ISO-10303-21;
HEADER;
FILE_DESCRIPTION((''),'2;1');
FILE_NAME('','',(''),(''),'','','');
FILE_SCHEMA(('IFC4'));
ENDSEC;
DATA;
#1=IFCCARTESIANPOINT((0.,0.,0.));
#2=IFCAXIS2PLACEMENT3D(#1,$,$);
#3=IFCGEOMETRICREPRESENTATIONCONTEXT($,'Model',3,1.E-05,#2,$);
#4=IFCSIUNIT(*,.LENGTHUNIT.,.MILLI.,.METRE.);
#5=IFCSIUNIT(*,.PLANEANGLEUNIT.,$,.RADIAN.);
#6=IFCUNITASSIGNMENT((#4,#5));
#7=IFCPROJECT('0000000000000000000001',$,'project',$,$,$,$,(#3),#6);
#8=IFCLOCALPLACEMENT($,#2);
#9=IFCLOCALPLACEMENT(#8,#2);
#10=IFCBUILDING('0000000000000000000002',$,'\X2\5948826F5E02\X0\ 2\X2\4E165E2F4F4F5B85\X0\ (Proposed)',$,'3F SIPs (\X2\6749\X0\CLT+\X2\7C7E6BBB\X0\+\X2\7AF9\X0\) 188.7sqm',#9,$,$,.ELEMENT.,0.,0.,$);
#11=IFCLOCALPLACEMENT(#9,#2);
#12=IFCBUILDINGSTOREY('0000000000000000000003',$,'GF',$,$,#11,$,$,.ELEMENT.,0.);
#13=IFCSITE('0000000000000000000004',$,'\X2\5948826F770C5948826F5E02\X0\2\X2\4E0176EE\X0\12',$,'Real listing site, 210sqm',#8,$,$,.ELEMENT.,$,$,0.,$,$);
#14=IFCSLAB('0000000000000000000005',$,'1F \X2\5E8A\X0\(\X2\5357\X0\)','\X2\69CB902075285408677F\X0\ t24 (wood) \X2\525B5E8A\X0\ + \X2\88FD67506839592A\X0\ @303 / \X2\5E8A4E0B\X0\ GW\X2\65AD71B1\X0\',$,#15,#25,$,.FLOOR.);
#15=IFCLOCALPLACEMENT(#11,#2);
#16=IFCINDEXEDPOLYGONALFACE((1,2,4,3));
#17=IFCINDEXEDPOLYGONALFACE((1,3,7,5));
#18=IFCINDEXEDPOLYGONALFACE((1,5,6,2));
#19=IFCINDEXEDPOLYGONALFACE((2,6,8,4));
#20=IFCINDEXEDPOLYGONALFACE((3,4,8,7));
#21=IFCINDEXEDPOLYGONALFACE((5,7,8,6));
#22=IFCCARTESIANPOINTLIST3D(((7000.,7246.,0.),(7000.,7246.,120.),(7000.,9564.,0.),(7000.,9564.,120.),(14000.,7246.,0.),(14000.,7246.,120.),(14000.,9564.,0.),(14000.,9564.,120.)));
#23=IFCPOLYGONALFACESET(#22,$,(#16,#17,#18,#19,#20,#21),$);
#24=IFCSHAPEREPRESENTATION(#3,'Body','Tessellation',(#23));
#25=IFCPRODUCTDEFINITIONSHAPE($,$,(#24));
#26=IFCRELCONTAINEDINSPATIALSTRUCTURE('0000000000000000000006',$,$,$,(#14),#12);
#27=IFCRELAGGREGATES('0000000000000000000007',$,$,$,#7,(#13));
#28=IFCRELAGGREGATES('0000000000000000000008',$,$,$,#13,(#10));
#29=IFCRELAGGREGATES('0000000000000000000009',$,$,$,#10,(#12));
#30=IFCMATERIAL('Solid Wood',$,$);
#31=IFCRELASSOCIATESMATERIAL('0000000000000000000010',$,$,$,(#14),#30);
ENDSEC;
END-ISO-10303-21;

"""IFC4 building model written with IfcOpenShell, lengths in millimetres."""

from ifc_helpers import new_model, si_unit, frame, frame_2d, origin, place, context, project, spatial, rectangle, extrude, material, element, save


model = new_model("IFC4")

# Units and contexts
model_context = context("Model", 3, precision=1e-05, world=origin())
ifc_project = project(units=[si_unit("LENGTHUNIT", "METRE", prefix="MILLI"), si_unit("PLANEANGLEUNIT", "RADIAN")], contexts=[model_context])

# Site, building, storey
site_placement = place(None, origin())
site = spatial("IfcSite", under=ifc_project, at=site_placement, Name="奈良県奈良市2丁目12", ObjectType="Real listing site, 210sqm", CompositionType="ELEMENT", RefElevation=0.0)
building_placement = place(site_placement, origin())
building = spatial("IfcBuilding", under=site, at=building_placement, Name="奈良市 2世帯住宅 (Proposed)", ObjectType="3F SIPs (杉CLT+籾殻+竹) 188.7sqm", CompositionType="ELEMENT", ElevationOfRefHeight=0.0, ElevationOfTerrain=0.0)
storey_placement = place(building_placement, origin())
storey = spatial("IfcBuildingStorey", under=building, at=storey_placement, Name="GF", CompositionType="ELEMENT", Elevation=0.0)

# Slab
ifc_material_1 = material(Name="Solid Wood")
slab_1_placement = place(storey_placement, frame((3500.0, 3623.0, 0.0)))
element("IfcSlab", 1, at=slab_1_placement, inside=storey, material=ifc_material_1, Name="1F 床(南)", Description="構造用合板 t24 (wood) 剛床 + 製材根太 @303 / 床下 GW断熱", PredefinedType="FLOOR", context=model_context, shape_type="SweptSolid", body=[
    extrude(rectangle(XDim=7000.0, YDim=2318.0, at=frame_2d((3500.0, 1159.0))), frame((3500.0, 3623.0, 0.0)), (0.0, 0.0, 1.0), 120.0),
])

save(model, "model.ifc")
